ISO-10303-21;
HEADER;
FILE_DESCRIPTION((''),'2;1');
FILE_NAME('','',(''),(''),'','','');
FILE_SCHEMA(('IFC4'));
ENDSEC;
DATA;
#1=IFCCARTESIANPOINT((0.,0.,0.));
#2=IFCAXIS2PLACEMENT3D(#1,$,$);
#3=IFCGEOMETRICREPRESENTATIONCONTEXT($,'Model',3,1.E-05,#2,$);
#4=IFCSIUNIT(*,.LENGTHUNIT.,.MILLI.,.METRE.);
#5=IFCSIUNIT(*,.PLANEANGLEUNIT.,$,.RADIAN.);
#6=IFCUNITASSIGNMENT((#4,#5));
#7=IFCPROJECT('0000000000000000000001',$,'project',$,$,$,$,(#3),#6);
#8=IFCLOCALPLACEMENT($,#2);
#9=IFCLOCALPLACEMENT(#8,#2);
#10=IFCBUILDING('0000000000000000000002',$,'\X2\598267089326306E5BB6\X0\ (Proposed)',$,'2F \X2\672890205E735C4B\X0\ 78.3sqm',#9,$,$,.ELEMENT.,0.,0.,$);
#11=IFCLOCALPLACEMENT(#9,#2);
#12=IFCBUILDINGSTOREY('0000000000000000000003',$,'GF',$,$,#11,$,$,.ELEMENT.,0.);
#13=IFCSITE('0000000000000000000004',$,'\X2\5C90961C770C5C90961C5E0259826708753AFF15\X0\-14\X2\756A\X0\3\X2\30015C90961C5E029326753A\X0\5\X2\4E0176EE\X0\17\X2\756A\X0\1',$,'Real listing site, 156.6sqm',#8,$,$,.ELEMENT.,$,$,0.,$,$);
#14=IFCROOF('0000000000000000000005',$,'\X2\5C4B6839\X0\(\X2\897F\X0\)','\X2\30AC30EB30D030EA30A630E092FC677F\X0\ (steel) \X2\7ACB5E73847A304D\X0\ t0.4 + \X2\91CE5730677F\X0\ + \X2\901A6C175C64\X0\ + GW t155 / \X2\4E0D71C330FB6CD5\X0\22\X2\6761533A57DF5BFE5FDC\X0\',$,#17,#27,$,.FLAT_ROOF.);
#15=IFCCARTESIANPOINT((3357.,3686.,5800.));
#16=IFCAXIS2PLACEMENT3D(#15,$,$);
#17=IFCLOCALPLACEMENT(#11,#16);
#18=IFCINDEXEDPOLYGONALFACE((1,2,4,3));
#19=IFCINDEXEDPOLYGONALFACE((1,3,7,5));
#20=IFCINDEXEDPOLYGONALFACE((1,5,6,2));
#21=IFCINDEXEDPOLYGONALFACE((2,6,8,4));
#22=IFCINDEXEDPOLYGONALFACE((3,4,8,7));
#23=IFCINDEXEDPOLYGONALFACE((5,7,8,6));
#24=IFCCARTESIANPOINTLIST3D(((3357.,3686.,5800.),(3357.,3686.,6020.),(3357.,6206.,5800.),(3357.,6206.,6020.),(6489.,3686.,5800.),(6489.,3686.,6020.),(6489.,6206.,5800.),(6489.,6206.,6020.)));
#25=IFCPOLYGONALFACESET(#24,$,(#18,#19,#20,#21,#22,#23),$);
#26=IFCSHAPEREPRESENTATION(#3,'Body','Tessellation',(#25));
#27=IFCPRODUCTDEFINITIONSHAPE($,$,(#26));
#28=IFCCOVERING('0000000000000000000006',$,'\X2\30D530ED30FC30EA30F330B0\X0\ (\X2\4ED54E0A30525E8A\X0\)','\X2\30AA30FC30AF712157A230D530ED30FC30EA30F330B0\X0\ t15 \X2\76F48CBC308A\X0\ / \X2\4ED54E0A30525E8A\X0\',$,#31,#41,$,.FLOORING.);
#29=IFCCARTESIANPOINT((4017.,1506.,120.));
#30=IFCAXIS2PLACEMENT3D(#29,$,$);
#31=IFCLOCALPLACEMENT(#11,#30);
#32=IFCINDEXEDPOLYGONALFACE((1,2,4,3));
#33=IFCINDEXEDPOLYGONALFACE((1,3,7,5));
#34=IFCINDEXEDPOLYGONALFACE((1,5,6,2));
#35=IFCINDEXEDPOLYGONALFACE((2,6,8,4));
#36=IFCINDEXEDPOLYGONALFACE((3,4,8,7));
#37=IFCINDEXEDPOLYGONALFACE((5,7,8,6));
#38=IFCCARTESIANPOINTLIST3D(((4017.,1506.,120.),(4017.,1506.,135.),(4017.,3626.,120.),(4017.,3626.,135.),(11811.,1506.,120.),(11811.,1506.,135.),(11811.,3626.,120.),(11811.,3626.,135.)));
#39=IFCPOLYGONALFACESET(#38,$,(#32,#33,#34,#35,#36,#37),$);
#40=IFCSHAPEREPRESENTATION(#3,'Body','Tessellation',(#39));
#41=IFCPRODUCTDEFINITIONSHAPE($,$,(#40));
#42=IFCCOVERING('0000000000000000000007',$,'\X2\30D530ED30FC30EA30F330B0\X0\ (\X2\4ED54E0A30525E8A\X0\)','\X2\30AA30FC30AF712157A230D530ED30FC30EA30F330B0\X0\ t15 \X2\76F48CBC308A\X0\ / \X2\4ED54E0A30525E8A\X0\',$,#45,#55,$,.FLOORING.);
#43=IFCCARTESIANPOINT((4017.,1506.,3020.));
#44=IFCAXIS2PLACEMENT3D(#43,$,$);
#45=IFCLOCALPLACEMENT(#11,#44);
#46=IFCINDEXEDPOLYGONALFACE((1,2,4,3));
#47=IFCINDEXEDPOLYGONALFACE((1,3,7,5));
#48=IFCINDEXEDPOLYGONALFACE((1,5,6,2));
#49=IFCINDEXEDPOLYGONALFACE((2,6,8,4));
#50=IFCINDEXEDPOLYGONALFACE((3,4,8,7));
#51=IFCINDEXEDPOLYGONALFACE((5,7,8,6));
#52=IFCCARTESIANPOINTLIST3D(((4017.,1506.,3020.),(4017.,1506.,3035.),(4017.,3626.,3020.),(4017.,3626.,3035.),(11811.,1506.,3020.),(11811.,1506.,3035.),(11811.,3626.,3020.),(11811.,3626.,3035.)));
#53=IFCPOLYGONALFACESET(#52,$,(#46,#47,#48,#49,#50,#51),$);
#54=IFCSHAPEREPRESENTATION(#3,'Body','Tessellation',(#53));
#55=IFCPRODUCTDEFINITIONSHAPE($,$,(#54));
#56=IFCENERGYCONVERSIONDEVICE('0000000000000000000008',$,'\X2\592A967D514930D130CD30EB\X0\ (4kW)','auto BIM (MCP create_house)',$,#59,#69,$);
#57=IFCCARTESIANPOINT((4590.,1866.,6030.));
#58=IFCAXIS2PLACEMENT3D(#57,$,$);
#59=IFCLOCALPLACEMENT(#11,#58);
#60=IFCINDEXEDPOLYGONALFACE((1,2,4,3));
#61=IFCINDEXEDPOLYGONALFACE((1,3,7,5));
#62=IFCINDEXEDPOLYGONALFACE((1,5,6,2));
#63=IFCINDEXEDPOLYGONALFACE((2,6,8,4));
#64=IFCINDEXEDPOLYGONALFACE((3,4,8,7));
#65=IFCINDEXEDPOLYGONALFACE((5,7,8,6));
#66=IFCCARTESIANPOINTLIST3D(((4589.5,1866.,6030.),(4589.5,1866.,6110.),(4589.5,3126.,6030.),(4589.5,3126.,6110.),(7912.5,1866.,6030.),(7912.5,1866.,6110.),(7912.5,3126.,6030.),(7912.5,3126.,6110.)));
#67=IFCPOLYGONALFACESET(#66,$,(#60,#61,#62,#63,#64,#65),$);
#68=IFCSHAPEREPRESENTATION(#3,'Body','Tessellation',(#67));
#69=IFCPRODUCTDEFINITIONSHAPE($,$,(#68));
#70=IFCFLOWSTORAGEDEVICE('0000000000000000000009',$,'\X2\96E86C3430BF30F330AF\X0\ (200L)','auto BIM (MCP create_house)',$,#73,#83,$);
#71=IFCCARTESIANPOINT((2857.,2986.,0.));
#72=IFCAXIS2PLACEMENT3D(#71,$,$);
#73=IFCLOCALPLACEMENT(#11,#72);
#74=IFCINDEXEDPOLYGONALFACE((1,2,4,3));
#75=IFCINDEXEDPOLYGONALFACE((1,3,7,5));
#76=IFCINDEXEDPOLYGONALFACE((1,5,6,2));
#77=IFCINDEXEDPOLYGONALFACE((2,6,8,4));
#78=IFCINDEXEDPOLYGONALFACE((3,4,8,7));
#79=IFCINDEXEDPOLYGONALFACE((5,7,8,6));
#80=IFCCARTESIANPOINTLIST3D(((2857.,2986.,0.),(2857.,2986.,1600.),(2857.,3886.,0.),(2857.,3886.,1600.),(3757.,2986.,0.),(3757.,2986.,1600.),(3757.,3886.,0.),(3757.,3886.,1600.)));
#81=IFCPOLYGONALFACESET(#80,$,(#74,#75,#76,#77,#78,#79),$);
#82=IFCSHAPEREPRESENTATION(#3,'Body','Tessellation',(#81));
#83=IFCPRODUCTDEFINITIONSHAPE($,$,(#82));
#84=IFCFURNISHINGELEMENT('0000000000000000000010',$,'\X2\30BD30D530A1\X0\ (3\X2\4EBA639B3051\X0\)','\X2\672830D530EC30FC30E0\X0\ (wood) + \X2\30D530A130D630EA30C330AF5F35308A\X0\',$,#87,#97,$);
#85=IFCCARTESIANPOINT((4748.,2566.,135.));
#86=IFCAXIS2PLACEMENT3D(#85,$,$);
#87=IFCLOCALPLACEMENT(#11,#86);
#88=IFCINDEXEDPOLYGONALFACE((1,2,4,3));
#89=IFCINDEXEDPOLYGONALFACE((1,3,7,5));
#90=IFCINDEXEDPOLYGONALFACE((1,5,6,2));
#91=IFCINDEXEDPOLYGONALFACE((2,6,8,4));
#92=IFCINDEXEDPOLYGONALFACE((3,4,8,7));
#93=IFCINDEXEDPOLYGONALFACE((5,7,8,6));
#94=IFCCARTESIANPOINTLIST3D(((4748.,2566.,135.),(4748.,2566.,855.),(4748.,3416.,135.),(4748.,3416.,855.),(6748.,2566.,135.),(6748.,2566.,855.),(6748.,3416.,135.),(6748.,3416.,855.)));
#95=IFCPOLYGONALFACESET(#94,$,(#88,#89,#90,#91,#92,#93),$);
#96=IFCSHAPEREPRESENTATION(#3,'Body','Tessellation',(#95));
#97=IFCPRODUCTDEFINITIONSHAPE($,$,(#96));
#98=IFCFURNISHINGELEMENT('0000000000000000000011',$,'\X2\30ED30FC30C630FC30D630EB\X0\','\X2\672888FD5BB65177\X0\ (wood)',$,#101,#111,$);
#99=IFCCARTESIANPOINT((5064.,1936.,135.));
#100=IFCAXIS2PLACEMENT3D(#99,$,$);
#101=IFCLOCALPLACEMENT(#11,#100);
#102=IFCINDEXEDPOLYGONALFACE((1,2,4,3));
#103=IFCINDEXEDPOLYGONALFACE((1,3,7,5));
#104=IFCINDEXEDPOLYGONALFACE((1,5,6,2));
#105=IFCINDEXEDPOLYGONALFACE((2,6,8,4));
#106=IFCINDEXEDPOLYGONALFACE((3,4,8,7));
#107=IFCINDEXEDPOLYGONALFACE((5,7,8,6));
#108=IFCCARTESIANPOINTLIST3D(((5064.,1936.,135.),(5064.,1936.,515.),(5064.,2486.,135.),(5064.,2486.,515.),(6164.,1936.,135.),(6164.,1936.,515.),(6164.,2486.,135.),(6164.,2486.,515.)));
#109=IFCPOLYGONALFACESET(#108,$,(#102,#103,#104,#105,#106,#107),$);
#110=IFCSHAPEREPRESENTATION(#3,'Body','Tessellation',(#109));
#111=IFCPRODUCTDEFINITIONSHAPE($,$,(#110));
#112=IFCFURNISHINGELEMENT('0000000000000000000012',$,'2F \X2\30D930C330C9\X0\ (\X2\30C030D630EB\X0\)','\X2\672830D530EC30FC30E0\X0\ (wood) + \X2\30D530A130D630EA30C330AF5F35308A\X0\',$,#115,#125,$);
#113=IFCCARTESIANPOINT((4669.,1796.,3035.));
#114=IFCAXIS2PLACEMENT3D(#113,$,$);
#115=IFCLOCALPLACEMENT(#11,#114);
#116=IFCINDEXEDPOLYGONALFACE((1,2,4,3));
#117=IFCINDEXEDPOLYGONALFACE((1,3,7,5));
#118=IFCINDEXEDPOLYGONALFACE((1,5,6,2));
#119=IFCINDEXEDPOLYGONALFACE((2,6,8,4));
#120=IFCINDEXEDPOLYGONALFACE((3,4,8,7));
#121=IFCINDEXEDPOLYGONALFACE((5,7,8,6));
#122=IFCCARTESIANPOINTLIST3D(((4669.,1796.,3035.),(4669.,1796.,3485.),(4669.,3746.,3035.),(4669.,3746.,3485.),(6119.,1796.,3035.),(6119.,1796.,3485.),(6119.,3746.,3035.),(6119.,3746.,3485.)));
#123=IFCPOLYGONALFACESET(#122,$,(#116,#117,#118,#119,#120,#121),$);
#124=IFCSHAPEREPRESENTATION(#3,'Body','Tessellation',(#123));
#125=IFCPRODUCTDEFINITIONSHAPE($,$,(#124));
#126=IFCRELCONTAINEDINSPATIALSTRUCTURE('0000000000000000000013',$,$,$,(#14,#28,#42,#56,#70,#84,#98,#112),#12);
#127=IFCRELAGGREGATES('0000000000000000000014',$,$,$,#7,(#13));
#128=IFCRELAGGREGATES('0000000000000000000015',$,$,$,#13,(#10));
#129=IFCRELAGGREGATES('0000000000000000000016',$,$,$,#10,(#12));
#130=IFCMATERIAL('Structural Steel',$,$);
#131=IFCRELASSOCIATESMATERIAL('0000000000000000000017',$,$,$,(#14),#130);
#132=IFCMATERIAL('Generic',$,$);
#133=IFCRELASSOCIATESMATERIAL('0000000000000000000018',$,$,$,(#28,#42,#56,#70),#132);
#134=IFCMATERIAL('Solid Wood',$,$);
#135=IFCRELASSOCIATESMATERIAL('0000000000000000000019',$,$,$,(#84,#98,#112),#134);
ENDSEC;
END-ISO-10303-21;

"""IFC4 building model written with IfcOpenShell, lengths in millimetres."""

from ifc_helpers import new_model, si_unit, frame, frame_2d, origin, place, context, project, spatial, rectangle, extrude, material, element, save


model = new_model("IFC4")

# Units and contexts
model_context = context("Model", 3, precision=1e-05, world=origin())
ifc_project = project(units=[si_unit("LENGTHUNIT", "METRE", prefix="MILLI"), si_unit("PLANEANGLEUNIT", "RADIAN")], contexts=[model_context])

# Site, building, storey
site_placement = place(None, origin())
site = spatial("IfcSite", under=ifc_project, at=site_placement, Name="岐阜県岐阜市如月町５-14番3、岐阜市錦町5丁目17番1", ObjectType="Real listing site, 156.6sqm", CompositionType="ELEMENT", RefElevation=0.0)
building_placement = place(site_placement, origin())
building = spatial("IfcBuilding", under=site, at=building_placement, Name="如月錦の家 (Proposed)", ObjectType="2F 木造平屋 78.3sqm", CompositionType="ELEMENT", ElevationOfRefHeight=0.0, ElevationOfTerrain=0.0)
storey_placement = place(building_placement, origin())
storey = spatial("IfcBuildingStorey", under=building, at=storey_placement, Name="GF", CompositionType="ELEMENT", Elevation=0.0)

# Shared definitions
ifc_material_1 = material(Name="Solid Wood")

# Roof
ifc_material_2 = material(Name="Structural Steel")
roof_1_placement = place(storey_placement, frame((3357.0, 3686.0, 5800.0)))
element("IfcRoof", 1, at=roof_1_placement, inside=storey, material=ifc_material_2, Name="屋根(西)", Description="ガルバリウム鋼板 (steel) 立平葺き t0.4 + 野地板 + 通気層 + GW t155 / 不燃・法22条区域対応", PredefinedType="FLAT_ROOF", context=model_context, shape_type="SweptSolid", body=[
    extrude(rectangle(XDim=3132.0, YDim=2520.0, at=frame_2d((1566.0, 1260.0))), frame((3357.0, 3686.0, 5800.0)), (0.0, 0.0, 1.0), 220.0),
])

# Coverings
ifc_material_3 = material(Name="Generic")
covering_1_placement = place(storey_placement, frame((4017.0, 1506.0, 120.0)))
element("IfcCovering", 2, at=covering_1_placement, inside=storey, material=ifc_material_3, Name="フローリング (仕上げ床)", Description="オーク無垢フローリング t15 直貼り / 仕上げ床", PredefinedType="FLOORING", context=model_context, shape_type="SweptSolid", body=[
    extrude(rectangle(XDim=7794.0, YDim=2120.0, at=frame_2d((3897.0, 1060.0))), frame((4017.0, 1506.0, 120.0)), (0.0, 0.0, 1.0), 15.0),
])
covering_2_placement = place(storey_placement, frame((4017.0, 1506.0, 3020.0)))
element("IfcCovering", 3, at=covering_2_placement, inside=storey, material=ifc_material_3, Name="フローリング (仕上げ床)", Description="オーク無垢フローリング t15 直貼り / 仕上げ床", PredefinedType="FLOORING", context=model_context, shape_type="SweptSolid", body=[
    extrude(rectangle(XDim=7794.0, YDim=2120.0, at=frame_2d((3897.0, 1060.0))), frame((4017.0, 1506.0, 3020.0)), (0.0, 0.0, 1.0), 15.0),
])

# Energy conversion device
energy_conversion_device_placement = place(storey_placement, frame((4590.0, 1866.0, 6030.0)))
element("IfcEnergyConversionDevice", 4, at=energy_conversion_device_placement, inside=storey, material=ifc_material_3, Name="太陽光パネル (4kW)", Description="auto BIM (MCP create_house)", context=model_context, shape_type="SweptSolid", body=[
    extrude(rectangle(XDim=3323.0, YDim=1260.0, at=frame_2d((1661.0, 630.0))), frame((4590.0, 1866.0, 6030.0)), (0.0, 0.0, 1.0), 80.0),
])

# Flow storage device
flow_storage_device_placement = place(storey_placement, frame((2857.0, 2986.0, 0.0)))
element("IfcFlowStorageDevice", 5, at=flow_storage_device_placement, inside=storey, material=ifc_material_3, Name="雨水タンク (200L)", Description="auto BIM (MCP create_house)", context=model_context, shape_type="SweptSolid", body=[
    extrude(rectangle(XDim=900.0, YDim=900.0, at=frame_2d((450.0, 450.0))), frame((2857.0, 2986.0, 0.0)), (0.0, 0.0, 1.0), 1600.0),
])

# Furnishing elements
furnishing_1_placement = place(storey_placement, frame((4748.0, 2566.0, 135.0)))
element("IfcFurnishingElement", 6, at=furnishing_1_placement, inside=storey, material=ifc_material_1, Name="ソファ (3人掛け)", Description="木フレーム (wood) + ファブリック張り", context=model_context, shape_type="SweptSolid", body=[
    extrude(rectangle(XDim=2000.0, YDim=850.0, at=frame_2d((1000.0, 425.0))), frame((4748.0, 2566.0, 135.0)), (0.0, 0.0, 1.0), 720.0),
])
furnishing_2_placement = place(storey_placement, frame((5064.0, 1936.0, 135.0)))
element("IfcFurnishingElement", 7, at=furnishing_2_placement, inside=storey, material=ifc_material_1, Name="ローテーブル", Description="木製家具 (wood)", context=model_context, shape_type="SweptSolid", body=[
    extrude(rectangle(XDim=1100.0, YDim=550.0, at=frame_2d((550.0, 275.0))), frame((5064.0, 1936.0, 135.0)), (0.0, 0.0, 1.0), 380.0),
])
furnishing_3_placement = place(storey_placement, frame((4669.0, 1796.0, 3035.0)))
element("IfcFurnishingElement", 8, at=furnishing_3_placement, inside=storey, material=ifc_material_1, Name="2F ベッド (ダブル)", Description="木フレーム (wood) + ファブリック張り", context=model_context, shape_type="SweptSolid", body=[
    extrude(rectangle(XDim=1450.0, YDim=1950.0, at=frame_2d((725.0, 975.0))), frame((4669.0, 1796.0, 3035.0)), (0.0, 0.0, 1.0), 450.0),
])

save(model, "model.ifc")
